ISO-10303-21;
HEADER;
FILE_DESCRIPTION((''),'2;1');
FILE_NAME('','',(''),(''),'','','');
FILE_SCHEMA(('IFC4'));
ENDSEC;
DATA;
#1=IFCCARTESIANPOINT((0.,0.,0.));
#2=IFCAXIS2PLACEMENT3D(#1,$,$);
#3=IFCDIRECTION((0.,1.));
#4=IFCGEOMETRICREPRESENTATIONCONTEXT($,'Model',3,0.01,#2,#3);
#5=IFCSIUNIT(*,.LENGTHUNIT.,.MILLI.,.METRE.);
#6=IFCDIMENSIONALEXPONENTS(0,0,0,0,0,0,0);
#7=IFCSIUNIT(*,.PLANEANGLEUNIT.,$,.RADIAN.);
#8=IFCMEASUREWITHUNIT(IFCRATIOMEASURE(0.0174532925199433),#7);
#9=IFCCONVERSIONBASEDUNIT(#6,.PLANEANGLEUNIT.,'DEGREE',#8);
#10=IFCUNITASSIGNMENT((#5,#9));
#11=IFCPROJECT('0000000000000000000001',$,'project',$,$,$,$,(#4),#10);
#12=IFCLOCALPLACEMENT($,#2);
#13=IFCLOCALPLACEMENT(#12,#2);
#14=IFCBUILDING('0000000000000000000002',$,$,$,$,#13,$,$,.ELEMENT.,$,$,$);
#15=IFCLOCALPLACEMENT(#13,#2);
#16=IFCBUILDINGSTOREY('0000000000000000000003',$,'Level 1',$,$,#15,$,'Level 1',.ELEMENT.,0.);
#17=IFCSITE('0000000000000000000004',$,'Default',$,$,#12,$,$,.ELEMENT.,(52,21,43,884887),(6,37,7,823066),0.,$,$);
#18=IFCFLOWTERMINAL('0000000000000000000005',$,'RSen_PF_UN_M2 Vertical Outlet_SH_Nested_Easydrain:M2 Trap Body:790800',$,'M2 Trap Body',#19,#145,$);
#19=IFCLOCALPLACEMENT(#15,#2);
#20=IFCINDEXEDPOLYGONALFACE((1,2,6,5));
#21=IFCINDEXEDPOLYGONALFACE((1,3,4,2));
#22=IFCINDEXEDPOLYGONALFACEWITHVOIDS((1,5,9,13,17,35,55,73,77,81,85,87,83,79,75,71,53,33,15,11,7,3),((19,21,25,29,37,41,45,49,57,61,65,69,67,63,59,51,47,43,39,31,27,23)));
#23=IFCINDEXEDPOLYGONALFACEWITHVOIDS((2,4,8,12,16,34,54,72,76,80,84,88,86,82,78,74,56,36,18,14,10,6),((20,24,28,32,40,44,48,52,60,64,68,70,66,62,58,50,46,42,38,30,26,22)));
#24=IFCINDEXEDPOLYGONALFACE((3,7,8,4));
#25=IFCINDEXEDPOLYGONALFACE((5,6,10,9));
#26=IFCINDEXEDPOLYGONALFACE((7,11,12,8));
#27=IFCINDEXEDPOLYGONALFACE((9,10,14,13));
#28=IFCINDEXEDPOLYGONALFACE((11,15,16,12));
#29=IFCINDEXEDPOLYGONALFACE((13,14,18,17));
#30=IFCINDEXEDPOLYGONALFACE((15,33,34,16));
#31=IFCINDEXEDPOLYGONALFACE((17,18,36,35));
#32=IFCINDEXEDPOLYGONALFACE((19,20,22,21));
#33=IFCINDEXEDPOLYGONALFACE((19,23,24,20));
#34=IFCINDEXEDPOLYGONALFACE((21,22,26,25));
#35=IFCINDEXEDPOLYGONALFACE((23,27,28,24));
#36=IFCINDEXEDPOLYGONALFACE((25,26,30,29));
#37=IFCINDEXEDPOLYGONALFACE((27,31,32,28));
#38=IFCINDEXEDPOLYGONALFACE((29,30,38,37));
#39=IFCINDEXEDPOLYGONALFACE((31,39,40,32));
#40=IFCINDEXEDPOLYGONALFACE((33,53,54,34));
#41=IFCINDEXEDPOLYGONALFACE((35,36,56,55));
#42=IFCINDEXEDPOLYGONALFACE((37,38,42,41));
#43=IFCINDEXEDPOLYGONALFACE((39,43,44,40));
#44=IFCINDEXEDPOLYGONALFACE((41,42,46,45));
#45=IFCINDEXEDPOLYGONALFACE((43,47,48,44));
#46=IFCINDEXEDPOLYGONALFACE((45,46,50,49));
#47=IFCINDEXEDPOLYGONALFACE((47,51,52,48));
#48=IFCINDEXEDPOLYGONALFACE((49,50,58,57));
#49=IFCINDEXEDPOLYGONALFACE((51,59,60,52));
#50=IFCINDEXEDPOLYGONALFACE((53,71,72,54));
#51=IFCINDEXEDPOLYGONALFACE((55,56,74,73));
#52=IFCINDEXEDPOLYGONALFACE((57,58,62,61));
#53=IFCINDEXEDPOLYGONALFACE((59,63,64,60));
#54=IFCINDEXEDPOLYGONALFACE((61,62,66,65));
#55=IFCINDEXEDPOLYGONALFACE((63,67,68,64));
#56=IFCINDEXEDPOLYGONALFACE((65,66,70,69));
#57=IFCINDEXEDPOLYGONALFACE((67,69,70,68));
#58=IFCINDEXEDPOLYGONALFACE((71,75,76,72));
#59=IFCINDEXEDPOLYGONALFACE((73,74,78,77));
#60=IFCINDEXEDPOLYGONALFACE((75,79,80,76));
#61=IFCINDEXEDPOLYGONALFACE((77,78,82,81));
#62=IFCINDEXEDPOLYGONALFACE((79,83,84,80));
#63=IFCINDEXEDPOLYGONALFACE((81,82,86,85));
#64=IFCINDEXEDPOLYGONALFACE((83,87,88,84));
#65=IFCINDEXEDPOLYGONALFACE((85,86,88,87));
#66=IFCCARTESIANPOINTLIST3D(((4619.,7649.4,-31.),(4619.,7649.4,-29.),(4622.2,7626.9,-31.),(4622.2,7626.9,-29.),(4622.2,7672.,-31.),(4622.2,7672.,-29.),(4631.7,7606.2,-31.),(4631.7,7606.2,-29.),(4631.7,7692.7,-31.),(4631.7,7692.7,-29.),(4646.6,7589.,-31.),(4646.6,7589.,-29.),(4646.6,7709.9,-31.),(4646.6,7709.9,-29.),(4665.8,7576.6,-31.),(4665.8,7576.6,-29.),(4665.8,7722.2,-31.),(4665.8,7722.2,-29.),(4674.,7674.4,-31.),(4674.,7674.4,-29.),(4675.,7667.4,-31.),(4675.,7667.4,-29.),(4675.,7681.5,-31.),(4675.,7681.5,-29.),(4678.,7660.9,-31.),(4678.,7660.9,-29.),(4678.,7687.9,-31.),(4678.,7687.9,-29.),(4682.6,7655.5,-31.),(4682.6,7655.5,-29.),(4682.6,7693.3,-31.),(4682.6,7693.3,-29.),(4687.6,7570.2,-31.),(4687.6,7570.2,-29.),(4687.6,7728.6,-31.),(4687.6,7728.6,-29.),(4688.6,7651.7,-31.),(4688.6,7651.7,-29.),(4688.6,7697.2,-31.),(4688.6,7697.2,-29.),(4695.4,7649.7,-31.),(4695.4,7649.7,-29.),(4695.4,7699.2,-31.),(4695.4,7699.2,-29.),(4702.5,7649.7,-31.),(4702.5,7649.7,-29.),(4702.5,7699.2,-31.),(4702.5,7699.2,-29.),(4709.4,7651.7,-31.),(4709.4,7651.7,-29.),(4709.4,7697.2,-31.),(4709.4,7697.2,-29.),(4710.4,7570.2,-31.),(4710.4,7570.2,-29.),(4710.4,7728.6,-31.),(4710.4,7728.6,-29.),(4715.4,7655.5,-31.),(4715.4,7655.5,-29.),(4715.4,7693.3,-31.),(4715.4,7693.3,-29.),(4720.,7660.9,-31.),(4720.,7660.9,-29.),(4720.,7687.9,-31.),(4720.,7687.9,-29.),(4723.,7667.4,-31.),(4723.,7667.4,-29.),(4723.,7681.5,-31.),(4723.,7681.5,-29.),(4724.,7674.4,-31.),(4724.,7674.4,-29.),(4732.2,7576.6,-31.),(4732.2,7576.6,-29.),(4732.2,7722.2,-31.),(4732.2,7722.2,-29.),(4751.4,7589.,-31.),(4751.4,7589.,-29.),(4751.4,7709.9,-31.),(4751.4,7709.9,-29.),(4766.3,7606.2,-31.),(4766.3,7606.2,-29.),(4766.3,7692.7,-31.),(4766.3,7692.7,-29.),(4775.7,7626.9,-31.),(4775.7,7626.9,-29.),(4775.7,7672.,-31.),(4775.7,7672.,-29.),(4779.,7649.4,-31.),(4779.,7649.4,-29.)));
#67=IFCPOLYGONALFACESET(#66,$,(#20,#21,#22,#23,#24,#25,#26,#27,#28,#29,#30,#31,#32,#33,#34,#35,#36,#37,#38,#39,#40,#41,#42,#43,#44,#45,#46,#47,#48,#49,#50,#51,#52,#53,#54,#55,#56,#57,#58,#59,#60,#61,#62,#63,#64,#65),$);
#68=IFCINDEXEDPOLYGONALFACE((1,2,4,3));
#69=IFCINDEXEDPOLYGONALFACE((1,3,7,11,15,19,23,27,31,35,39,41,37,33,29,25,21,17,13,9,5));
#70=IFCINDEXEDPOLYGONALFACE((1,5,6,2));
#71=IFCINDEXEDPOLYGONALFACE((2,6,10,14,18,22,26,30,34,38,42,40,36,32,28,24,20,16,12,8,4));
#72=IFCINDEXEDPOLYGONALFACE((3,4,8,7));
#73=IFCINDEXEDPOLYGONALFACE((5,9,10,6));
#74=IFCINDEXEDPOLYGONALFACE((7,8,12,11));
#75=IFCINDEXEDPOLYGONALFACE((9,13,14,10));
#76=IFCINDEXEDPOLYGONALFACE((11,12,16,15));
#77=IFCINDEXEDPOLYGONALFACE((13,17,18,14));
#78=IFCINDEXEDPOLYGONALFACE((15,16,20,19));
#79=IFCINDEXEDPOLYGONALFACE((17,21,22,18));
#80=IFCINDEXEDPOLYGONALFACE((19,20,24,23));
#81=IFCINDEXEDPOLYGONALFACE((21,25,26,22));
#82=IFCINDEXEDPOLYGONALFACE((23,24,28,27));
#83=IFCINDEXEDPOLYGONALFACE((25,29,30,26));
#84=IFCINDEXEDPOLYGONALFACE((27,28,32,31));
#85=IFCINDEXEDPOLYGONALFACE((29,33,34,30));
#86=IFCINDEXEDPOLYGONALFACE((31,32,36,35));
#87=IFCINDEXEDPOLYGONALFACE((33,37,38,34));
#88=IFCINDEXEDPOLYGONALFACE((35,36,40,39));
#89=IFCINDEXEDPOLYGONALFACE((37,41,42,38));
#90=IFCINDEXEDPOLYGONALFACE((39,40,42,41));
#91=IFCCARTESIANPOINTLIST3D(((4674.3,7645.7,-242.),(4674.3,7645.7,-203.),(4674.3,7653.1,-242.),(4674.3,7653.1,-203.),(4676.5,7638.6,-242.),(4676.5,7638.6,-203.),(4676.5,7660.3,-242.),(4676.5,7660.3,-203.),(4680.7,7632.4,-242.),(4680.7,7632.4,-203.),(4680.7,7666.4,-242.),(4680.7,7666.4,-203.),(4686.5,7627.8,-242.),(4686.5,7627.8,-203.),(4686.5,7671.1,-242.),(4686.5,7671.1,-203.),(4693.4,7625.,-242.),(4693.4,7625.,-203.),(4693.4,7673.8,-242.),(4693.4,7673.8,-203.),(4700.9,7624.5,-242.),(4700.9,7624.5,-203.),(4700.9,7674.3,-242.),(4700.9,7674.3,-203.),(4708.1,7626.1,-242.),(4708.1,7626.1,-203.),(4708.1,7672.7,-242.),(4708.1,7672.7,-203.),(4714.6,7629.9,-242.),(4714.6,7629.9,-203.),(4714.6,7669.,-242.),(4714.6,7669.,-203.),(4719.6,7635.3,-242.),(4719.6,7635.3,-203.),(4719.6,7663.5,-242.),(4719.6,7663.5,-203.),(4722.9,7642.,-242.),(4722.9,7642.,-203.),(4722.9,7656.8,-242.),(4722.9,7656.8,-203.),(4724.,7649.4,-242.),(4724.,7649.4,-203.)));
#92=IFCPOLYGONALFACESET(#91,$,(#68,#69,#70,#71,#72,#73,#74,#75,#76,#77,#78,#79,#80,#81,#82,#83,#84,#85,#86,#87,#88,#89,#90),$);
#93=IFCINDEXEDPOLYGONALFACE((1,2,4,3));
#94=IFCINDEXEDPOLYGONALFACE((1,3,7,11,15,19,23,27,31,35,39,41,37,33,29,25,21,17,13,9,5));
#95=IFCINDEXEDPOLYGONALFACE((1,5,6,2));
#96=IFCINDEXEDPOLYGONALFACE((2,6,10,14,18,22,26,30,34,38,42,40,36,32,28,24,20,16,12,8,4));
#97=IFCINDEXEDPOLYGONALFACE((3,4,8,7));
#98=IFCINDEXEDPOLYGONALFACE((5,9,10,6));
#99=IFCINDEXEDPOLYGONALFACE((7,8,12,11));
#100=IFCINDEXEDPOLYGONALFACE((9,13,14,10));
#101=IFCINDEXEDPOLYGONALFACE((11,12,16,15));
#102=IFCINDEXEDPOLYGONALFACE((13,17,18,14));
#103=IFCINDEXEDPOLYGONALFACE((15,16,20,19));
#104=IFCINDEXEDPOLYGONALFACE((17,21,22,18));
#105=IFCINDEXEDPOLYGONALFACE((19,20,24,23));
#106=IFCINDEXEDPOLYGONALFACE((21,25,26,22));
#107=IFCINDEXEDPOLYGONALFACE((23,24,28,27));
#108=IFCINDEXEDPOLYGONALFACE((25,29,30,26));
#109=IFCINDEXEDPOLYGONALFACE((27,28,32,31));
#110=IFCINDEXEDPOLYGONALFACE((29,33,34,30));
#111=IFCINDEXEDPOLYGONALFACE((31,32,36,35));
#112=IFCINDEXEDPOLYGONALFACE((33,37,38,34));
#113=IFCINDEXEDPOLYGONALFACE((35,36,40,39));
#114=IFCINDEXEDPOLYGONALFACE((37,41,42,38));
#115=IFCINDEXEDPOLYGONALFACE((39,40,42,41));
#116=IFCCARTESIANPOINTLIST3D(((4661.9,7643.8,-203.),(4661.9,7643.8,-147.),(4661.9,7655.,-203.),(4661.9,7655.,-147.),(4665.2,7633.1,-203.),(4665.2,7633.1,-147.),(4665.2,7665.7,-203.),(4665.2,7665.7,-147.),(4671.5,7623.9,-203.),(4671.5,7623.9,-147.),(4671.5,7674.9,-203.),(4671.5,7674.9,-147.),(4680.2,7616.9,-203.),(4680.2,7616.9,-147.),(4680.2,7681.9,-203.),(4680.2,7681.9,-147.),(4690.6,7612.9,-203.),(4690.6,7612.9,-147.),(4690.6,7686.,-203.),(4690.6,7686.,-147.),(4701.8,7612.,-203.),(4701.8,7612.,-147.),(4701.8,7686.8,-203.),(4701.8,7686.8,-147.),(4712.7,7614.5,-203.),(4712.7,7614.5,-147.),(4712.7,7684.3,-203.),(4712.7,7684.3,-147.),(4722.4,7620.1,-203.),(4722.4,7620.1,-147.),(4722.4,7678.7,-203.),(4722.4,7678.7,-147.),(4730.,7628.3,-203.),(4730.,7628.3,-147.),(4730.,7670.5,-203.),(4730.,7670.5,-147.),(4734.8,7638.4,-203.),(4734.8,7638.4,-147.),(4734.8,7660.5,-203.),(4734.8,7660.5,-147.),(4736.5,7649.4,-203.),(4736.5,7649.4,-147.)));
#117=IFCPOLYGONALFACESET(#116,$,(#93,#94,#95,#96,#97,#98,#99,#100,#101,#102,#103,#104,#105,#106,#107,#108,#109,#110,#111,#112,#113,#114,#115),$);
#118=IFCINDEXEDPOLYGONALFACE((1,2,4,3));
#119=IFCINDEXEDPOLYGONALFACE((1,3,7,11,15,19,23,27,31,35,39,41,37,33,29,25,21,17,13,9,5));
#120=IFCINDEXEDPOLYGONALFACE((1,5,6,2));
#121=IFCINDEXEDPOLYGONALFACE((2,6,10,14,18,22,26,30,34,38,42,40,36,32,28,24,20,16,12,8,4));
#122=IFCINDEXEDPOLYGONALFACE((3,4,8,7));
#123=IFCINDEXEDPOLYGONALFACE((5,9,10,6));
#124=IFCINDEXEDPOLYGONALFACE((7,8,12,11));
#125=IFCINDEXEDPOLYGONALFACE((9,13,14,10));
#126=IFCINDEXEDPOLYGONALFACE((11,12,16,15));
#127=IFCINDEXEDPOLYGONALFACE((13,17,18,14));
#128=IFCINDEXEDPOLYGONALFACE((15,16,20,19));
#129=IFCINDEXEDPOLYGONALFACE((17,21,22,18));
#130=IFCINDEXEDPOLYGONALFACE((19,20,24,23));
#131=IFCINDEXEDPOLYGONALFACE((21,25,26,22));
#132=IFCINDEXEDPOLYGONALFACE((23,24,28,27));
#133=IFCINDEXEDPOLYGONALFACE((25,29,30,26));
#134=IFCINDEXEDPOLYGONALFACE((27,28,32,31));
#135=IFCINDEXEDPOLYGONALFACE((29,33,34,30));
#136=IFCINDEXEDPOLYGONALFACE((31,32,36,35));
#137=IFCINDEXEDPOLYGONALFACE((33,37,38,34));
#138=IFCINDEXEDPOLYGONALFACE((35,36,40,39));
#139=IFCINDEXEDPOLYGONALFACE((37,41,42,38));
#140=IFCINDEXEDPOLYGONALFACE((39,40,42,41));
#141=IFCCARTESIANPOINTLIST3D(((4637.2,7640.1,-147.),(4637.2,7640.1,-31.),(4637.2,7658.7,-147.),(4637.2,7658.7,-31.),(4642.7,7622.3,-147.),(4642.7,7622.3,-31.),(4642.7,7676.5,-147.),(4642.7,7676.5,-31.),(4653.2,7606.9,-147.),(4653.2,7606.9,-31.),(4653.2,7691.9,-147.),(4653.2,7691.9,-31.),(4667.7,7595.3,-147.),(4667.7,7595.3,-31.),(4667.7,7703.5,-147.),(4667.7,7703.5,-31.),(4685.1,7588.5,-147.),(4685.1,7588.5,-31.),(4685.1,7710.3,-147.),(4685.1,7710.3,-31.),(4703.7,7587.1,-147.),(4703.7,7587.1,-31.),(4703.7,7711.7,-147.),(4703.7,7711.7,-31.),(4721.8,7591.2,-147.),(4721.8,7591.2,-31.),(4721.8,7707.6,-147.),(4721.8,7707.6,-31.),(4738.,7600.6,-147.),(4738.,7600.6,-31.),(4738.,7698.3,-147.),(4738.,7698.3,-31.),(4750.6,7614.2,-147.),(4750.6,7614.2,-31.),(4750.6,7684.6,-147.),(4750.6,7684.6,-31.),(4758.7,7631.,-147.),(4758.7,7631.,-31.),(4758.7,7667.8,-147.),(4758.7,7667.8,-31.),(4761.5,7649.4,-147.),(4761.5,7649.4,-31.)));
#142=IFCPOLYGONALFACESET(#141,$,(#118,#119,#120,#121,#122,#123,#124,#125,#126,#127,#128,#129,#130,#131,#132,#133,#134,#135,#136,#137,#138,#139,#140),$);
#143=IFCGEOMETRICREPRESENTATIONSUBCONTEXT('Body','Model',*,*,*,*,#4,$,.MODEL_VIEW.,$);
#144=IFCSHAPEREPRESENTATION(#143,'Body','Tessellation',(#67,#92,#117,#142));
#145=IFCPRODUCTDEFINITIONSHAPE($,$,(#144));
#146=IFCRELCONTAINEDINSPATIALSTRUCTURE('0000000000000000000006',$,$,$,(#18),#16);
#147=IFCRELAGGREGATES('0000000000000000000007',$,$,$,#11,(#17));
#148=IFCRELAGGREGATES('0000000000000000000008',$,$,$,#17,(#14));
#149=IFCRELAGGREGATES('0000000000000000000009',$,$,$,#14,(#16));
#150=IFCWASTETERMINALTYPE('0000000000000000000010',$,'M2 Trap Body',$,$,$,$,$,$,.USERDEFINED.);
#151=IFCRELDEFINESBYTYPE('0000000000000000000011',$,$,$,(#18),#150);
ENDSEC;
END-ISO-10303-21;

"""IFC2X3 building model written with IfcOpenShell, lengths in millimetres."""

from ifc_helpers import new_model, entity, si_unit, converted_unit, direction, frame, frame_2d, origin, origin_2d_with_axis, place, context, subcontext, project, spatial, circle_curve, parameter, trimmed, segment, composite_curve, circle, outline, extrude, source, transform, mapped, type_object, type_shapes, element, save


model = new_model("IFC2X3")

# Units and contexts
model_context = context("Model", 3, precision=0.01, world=origin(), true_north=direction((0.0, 1.0)))
body_context = subcontext(model_context, "Body", "Model", "MODEL_VIEW")
ifc_project = project(units=[si_unit("LENGTHUNIT", "METRE", prefix="MILLI"), converted_unit("PLANEANGLEUNIT", "DEGREE", entity("IfcRatioMeasure", 0.0174532925199433), si_unit("PLANEANGLEUNIT", "RADIAN"), dimensions=[0, 0, 0, 0, 0, 0, 0])], contexts=[model_context])

# Site, building, storey
site_placement = place(None, origin())
site = spatial("IfcSite", under=ifc_project, at=site_placement, Name="Default", CompositionType="ELEMENT", RefLatitude=(52, 21, 43, 884887), RefLongitude=(6, 37, 7, 823066), RefElevation=0.0)
building_placement = place(site_placement, origin())
building = spatial("IfcBuilding", under=site, at=building_placement, CompositionType="ELEMENT")
storey_placement = place(building_placement, origin())
storey = spatial("IfcBuildingStorey", under=building, at=storey_placement, Name="Level 1", LongName="Level 1", CompositionType="ELEMENT", Elevation=0.0)

# Flow terminal
waste_terminal_type_1 = type_object("IfcWasteTerminalType", Name="M2 Trap Body", PredefinedType="USERDEFINED")
shared_shape_1 = source(origin(), body_context, "Body", "SweptSolid", [
    extrude(outline(composite_curve([segment(trimmed(circle_curve(origin_2d_with_axis(), 80.0), [parameter(0.0)], [parameter(180.0)], True, "PARAMETER"), True, "CONTINUOUS"), segment(trimmed(circle_curve(origin_2d_with_axis(), 80.0), [parameter(180.0)], [parameter(360.0)], True, "PARAMETER"), True, "CONTINUOUS")], self_intersect=False), holes=[composite_curve([segment(trimmed(circle_curve(frame_2d((0.0, 25.0), x_axis=(1.0, 0.0)), 25.0), [parameter(180.0)], [parameter(360.0)], True, "PARAMETER"), False, "CONTINUOUS"), segment(trimmed(circle_curve(frame_2d((0.0, 25.0), x_axis=(1.0, 0.0)), 25.0), [parameter(0.0)], [parameter(180.0)], True, "PARAMETER"), False, "CONTINUOUS")], self_intersect=False)]), frame((0.0, -25.0, -2.0)), (0.0, 0.0, 1.0), 2.0),
    extrude(circle(Radius=25.0, at=frame_2d((0.0, 0.0), x_axis=(1.0, 0.0))), frame((0.0, -25.0, -213.0)), (0.0, 0.0, 1.0), 39.0),
    extrude(circle(Radius=37.5, at=frame_2d((0.0, 0.0), x_axis=(1.0, 0.0))), frame((0.0, -25.0, -174.0)), (0.0, 0.0, 1.0), 56.0),
    extrude(circle(Radius=62.5, at=frame_2d((0.0, 0.0), x_axis=(1.0, 0.0))), frame((0.0, -25.0, -118.0)), (0.0, 0.0, 1.0), 116.0),
])
type_shapes(waste_terminal_type_1, [shared_shape_1])
for number, where, name in (
    (1, (4699.0, 7674.4, -29.0), "RSen_PF_UN_M2 Vertical Outlet_SH_Nested_Easydrain:M2 Trap Body:790800"),
):
    element("IfcFlowTerminal", number, at=place(storey_placement, frame(where)), inside=storey, type_object=waste_terminal_type_1, Name=name, ObjectType="M2 Trap Body", context=body_context, shape_type="MappedRepresentation", body=[
        mapped(shared_shape_1, transform((0.0, 0.0, 0.0), scale=1.0)),
    ])

save(model, "model.ifc")
